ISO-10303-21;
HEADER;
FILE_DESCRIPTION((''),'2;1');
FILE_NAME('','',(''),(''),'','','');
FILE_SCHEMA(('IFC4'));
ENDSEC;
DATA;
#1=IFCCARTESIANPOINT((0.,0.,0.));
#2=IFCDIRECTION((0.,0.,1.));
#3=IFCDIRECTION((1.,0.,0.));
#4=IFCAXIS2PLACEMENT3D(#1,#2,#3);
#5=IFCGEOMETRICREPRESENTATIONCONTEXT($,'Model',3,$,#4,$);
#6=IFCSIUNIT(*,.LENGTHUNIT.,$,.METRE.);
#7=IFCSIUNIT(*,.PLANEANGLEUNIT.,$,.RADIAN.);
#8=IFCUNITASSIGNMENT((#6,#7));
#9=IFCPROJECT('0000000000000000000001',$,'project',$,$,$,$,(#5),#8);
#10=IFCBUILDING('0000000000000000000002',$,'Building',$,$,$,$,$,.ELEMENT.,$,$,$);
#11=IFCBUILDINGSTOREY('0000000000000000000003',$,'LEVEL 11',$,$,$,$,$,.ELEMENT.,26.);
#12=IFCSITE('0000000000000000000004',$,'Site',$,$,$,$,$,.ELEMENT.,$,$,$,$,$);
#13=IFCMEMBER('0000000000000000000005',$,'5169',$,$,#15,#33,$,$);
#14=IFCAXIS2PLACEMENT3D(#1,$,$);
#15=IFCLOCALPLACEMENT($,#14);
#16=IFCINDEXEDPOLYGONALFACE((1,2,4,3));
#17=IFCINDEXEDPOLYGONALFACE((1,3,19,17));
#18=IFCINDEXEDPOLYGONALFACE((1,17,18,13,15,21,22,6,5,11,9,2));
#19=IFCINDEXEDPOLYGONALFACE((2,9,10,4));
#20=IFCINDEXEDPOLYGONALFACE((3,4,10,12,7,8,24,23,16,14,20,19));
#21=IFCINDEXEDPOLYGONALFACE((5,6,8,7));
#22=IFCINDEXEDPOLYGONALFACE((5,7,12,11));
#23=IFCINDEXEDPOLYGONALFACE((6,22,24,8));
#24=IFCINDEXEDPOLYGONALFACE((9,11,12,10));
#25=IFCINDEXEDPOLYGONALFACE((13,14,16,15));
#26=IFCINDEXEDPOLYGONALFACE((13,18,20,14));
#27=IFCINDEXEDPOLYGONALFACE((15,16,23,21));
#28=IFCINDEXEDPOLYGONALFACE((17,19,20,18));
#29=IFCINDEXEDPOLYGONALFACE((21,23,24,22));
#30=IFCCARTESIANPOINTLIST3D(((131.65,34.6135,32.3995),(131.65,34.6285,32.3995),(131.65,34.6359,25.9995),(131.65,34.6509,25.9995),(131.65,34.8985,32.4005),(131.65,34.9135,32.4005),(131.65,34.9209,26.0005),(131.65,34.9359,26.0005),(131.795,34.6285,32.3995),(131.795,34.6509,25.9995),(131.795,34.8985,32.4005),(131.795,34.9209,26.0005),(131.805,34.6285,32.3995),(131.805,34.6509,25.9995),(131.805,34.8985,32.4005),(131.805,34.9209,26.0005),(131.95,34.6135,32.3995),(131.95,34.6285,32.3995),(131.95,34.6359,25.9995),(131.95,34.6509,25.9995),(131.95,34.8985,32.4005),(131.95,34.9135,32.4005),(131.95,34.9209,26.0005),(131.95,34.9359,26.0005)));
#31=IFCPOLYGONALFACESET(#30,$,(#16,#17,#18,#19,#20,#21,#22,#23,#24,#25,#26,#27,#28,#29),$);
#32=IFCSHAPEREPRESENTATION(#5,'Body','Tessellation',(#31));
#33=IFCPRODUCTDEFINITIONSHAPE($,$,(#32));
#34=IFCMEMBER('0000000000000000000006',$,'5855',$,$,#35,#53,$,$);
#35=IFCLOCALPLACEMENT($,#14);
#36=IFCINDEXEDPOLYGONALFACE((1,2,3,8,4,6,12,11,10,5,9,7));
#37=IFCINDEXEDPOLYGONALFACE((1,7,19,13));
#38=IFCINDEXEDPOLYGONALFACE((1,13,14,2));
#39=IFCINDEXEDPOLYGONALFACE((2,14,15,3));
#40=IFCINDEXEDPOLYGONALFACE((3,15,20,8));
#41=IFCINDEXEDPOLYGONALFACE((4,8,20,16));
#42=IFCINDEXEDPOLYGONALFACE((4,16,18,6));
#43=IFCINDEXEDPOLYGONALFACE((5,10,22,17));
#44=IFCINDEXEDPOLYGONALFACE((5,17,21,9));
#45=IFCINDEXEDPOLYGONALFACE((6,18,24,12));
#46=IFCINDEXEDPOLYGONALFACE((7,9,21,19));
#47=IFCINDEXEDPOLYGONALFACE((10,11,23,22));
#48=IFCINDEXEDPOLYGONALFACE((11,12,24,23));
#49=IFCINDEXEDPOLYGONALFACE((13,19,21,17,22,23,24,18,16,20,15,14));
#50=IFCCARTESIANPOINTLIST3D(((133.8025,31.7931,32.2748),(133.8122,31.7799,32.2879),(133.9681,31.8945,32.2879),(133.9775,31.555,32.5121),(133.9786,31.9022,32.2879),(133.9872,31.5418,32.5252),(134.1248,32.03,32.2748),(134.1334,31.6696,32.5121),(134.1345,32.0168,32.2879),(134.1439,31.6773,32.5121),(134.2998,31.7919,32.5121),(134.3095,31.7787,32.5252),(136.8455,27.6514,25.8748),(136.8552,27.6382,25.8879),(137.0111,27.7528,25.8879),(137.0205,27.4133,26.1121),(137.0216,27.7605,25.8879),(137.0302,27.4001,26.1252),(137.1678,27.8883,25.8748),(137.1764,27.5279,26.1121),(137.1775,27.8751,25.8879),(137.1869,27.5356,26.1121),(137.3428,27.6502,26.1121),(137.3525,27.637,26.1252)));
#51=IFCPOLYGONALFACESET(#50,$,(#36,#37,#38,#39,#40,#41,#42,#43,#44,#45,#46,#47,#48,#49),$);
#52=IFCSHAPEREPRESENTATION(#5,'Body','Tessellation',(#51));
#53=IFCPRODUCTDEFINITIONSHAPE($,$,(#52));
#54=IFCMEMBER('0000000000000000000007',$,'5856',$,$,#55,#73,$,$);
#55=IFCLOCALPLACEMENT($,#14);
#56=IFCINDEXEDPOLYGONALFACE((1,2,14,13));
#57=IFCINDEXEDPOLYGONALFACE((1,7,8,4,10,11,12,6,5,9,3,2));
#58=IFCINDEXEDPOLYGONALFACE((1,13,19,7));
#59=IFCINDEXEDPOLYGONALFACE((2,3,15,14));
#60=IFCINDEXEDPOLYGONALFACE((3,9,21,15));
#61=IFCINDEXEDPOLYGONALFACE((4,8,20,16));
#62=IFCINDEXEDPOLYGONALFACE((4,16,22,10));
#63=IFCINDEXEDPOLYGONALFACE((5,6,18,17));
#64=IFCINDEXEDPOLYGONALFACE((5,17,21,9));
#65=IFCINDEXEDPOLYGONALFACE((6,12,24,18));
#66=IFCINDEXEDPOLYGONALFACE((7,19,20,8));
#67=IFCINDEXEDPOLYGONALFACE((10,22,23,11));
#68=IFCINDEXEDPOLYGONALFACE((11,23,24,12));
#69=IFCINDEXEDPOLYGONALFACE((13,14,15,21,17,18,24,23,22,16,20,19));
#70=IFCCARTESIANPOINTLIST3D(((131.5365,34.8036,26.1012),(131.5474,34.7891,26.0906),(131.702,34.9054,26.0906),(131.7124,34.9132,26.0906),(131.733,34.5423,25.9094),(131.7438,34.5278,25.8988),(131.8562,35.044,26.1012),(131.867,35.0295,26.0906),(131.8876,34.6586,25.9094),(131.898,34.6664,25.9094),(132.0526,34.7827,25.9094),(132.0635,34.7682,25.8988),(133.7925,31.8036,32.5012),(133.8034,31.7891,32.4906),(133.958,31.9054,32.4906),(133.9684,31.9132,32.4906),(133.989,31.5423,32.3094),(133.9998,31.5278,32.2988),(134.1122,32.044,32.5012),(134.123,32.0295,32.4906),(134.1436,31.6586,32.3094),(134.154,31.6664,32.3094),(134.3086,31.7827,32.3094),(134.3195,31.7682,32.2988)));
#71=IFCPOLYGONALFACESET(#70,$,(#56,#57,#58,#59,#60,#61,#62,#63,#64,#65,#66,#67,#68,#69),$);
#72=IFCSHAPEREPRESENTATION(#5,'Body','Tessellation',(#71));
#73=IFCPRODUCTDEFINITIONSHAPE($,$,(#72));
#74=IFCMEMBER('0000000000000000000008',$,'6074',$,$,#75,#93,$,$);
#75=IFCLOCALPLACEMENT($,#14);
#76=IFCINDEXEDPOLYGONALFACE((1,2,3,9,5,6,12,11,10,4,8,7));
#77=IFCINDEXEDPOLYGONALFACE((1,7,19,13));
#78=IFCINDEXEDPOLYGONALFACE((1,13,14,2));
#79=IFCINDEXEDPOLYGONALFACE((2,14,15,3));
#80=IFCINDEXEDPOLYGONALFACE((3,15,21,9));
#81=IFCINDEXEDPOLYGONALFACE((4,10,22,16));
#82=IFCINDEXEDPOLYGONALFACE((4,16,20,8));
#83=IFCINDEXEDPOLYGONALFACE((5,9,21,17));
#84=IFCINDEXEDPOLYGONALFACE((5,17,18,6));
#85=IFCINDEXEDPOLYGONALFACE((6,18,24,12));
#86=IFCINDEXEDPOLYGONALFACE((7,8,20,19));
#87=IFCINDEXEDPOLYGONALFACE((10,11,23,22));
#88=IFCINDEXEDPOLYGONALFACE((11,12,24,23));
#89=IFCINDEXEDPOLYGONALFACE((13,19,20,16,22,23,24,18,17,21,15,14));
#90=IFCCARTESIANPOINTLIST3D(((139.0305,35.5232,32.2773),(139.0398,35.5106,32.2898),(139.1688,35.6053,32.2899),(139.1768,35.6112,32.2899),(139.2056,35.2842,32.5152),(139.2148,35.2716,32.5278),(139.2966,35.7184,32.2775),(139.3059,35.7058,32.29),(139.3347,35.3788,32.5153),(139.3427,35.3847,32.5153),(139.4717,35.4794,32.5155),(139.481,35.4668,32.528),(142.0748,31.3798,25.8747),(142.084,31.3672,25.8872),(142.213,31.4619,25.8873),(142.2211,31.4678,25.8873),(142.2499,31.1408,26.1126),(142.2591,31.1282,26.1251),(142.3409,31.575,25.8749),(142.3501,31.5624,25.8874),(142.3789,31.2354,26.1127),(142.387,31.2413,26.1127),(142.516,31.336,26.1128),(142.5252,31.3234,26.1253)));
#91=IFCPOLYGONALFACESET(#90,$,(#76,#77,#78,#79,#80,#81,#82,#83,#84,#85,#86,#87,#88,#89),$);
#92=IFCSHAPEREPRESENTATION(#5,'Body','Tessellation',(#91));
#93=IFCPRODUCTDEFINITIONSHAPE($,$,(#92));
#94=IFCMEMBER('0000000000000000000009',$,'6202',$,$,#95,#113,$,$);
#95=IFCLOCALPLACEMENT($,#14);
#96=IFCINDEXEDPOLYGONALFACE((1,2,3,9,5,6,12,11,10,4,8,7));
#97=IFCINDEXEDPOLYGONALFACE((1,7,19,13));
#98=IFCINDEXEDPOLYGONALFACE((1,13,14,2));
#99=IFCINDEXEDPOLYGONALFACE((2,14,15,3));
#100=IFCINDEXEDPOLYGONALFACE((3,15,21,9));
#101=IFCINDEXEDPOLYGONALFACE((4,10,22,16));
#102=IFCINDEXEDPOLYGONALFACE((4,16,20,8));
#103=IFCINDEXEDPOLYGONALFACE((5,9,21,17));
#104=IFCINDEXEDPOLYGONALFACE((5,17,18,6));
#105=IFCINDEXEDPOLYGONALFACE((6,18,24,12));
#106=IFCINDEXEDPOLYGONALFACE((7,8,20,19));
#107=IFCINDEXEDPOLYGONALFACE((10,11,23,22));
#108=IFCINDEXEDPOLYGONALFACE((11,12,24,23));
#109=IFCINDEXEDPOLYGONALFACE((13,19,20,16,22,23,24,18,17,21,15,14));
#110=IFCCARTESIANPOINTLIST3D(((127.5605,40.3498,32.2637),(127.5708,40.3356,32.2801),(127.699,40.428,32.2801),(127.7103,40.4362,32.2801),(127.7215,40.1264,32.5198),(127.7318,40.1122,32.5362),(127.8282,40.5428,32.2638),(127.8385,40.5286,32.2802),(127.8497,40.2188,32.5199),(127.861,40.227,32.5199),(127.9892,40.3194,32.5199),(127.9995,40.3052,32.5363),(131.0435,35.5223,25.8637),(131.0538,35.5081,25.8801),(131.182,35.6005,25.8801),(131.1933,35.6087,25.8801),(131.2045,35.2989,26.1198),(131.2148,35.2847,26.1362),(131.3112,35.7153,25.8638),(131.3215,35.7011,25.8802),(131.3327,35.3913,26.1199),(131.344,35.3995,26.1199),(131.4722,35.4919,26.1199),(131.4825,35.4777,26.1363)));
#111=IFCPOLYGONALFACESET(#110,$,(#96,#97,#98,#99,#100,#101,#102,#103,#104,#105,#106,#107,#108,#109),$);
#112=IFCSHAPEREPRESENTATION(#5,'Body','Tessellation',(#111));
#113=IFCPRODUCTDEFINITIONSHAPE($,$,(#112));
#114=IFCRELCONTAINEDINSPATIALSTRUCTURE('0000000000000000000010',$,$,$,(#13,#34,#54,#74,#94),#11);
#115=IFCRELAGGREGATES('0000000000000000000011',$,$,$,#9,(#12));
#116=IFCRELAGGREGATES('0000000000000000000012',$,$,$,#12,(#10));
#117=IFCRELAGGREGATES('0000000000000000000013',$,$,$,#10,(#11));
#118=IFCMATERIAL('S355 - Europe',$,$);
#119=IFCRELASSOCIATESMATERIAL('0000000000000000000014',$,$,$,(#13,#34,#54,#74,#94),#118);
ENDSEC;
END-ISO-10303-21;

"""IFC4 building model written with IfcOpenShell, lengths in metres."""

from ifc_helpers import new_model, si_unit, frame, origin_with_axes, origin_2d_with_axis, place, context, project, spatial, i_section, extrude, material, material_profile, profile_set, profile_usage, element, save


model = new_model("IFC4")

# Units and contexts
model_context = context("Model", 3, world=origin_with_axes())
ifc_project = project(units=[si_unit("LENGTHUNIT", "METRE"), si_unit("PLANEANGLEUNIT", "RADIAN")], contexts=[model_context])

# Site, building, storey
site = spatial("IfcSite", under=ifc_project, Name="Site", CompositionType="ELEMENT")
building = spatial("IfcBuilding", under=site, Name="Building", CompositionType="ELEMENT")
storey = spatial("IfcBuildingStorey", under=building, Name="LEVEL 11", CompositionType="ELEMENT", Elevation=26.0)

# Shared definitions
ifc_material = material(Name="S355 - Europe")

# Members
ifc_material_profile_1 = material_profile(ifc_material, i_section(OverallWidth=0.3, OverallDepth=0.3, WebThickness=0.01, FlangeThickness=0.015, at=origin_2d_with_axis()))
ifc_profile_set_1 = profile_set([ifc_material_profile_1])
ifc_profile_usage_1 = profile_usage(ifc_profile_set_1, cardinal=10)
member_1_placement = place(None, frame((131.8, 34.7859, 26.0), z_axis=(0.0, -0.0035, 0.999994), x_axis=(1.0, 0.0, 0.0)))
element("IfcMember", 1, at=member_1_placement, inside=storey, material=ifc_profile_usage_1, Name="5169", context=model_context, shape_type="SweptSolid", body=[
    extrude(i_section(OverallWidth=0.3, OverallDepth=0.3, WebThickness=0.01, FlangeThickness=0.015, at=origin_2d_with_axis()), origin_with_axes(), (0.0, 0.0, 1.0), 6.4),
])
ifc_material_profile_2 = material_profile(ifc_material, i_section(OverallWidth=0.4, OverallDepth=0.4, WebThickness=0.013, FlangeThickness=0.021, at=origin_2d_with_axis()))
ifc_profile_set_2 = profile_set([ifc_material_profile_2])
ifc_profile_usage_2 = profile_usage(ifc_profile_set_2, cardinal=10)
member_2_placement = place(None, frame((137.099, 27.6442, 26.0), z_axis=(-0.37073, 0.504585, 0.779714), x_axis=(-0.805765, -0.592235, 0.0)))
element("IfcMember", 2, at=member_2_placement, inside=storey, material=ifc_profile_usage_2, Name="5855", context=model_context, shape_type="SweptSolid", body=[
    extrude(i_section(OverallWidth=0.4, OverallDepth=0.4, WebThickness=0.013, FlangeThickness=0.021, at=origin_2d_with_axis()), origin_with_axes(), (0.0, 0.0, 1.0), 8.2081),
])
ifc_material_profile_3 = material_profile(ifc_material, i_section(OverallWidth=0.4, OverallDepth=0.4, WebThickness=0.013, FlangeThickness=0.021, at=origin_2d_with_axis()))
ifc_profile_set_3 = profile_set([ifc_material_profile_3])
ifc_profile_usage_3 = profile_usage(ifc_profile_set_3, cardinal=10)
member_3_placement = place(None, frame((134.056, 31.7859, 32.4), z_axis=(-0.304062, 0.404338, -0.862587), x_axis=(-0.799232, -0.601023, 0.0)))
element("IfcMember", 3, at=member_3_placement, inside=storey, material=ifc_profile_usage_3, Name="5856", context=model_context, shape_type="SweptSolid", body=[
    extrude(i_section(OverallWidth=0.4, OverallDepth=0.4, WebThickness=0.013, FlangeThickness=0.021, at=origin_2d_with_axis()), origin_with_axes(), (0.0, 0.0, 1.0), 7.4195),
])
ifc_material_profile_4 = material_profile(ifc_material, i_section(OverallWidth=0.33, OverallDepth=0.4, WebThickness=0.01, FlangeThickness=0.02, at=origin_2d_with_axis()))
ifc_profile_set_4 = profile_set([ifc_material_profile_4])
ifc_profile_usage_4 = profile_usage(ifc_profile_set_4, cardinal=10)
member_4_placement = place(None, frame((142.3, 31.3516, 26.0), z_axis=(-0.37073, 0.504585, 0.779714), x_axis=(-0.806706, -0.590953, 0.0)))
element("IfcMember", 4, at=member_4_placement, inside=storey, material=ifc_profile_usage_4, Name="6074", context=model_context, shape_type="SweptSolid", body=[
    extrude(i_section(OverallWidth=0.33, OverallDepth=0.4, WebThickness=0.01, FlangeThickness=0.02, at=origin_2d_with_axis()), origin_with_axes(), (0.0, 0.0, 1.0), 8.2115),
])
ifc_material_profile_5 = material_profile(ifc_material, i_section(OverallWidth=0.33, OverallDepth=0.4, WebThickness=0.014, FlangeThickness=0.024, at=origin_2d_with_axis()))
ifc_profile_set_5 = profile_set([ifc_material_profile_5])
ifc_profile_usage_5 = profile_usage(ifc_profile_set_5, cardinal=10)
member_5_placement = place(None, frame((131.263, 35.5, 26.0), z_axis=(-0.398491, 0.552315, 0.732225), x_axis=(-0.811322, -0.584599, 0.0)))
element("IfcMember", 5, at=member_5_placement, inside=storey, material=ifc_profile_usage_5, Name="6202", context=model_context, shape_type="SweptSolid", body=[
    extrude(i_section(OverallWidth=0.33, OverallDepth=0.4, WebThickness=0.014, FlangeThickness=0.024, at=origin_2d_with_axis()), origin_with_axes(), (0.0, 0.0, 1.0), 8.7405),
])

save(model, "model.ifc")
